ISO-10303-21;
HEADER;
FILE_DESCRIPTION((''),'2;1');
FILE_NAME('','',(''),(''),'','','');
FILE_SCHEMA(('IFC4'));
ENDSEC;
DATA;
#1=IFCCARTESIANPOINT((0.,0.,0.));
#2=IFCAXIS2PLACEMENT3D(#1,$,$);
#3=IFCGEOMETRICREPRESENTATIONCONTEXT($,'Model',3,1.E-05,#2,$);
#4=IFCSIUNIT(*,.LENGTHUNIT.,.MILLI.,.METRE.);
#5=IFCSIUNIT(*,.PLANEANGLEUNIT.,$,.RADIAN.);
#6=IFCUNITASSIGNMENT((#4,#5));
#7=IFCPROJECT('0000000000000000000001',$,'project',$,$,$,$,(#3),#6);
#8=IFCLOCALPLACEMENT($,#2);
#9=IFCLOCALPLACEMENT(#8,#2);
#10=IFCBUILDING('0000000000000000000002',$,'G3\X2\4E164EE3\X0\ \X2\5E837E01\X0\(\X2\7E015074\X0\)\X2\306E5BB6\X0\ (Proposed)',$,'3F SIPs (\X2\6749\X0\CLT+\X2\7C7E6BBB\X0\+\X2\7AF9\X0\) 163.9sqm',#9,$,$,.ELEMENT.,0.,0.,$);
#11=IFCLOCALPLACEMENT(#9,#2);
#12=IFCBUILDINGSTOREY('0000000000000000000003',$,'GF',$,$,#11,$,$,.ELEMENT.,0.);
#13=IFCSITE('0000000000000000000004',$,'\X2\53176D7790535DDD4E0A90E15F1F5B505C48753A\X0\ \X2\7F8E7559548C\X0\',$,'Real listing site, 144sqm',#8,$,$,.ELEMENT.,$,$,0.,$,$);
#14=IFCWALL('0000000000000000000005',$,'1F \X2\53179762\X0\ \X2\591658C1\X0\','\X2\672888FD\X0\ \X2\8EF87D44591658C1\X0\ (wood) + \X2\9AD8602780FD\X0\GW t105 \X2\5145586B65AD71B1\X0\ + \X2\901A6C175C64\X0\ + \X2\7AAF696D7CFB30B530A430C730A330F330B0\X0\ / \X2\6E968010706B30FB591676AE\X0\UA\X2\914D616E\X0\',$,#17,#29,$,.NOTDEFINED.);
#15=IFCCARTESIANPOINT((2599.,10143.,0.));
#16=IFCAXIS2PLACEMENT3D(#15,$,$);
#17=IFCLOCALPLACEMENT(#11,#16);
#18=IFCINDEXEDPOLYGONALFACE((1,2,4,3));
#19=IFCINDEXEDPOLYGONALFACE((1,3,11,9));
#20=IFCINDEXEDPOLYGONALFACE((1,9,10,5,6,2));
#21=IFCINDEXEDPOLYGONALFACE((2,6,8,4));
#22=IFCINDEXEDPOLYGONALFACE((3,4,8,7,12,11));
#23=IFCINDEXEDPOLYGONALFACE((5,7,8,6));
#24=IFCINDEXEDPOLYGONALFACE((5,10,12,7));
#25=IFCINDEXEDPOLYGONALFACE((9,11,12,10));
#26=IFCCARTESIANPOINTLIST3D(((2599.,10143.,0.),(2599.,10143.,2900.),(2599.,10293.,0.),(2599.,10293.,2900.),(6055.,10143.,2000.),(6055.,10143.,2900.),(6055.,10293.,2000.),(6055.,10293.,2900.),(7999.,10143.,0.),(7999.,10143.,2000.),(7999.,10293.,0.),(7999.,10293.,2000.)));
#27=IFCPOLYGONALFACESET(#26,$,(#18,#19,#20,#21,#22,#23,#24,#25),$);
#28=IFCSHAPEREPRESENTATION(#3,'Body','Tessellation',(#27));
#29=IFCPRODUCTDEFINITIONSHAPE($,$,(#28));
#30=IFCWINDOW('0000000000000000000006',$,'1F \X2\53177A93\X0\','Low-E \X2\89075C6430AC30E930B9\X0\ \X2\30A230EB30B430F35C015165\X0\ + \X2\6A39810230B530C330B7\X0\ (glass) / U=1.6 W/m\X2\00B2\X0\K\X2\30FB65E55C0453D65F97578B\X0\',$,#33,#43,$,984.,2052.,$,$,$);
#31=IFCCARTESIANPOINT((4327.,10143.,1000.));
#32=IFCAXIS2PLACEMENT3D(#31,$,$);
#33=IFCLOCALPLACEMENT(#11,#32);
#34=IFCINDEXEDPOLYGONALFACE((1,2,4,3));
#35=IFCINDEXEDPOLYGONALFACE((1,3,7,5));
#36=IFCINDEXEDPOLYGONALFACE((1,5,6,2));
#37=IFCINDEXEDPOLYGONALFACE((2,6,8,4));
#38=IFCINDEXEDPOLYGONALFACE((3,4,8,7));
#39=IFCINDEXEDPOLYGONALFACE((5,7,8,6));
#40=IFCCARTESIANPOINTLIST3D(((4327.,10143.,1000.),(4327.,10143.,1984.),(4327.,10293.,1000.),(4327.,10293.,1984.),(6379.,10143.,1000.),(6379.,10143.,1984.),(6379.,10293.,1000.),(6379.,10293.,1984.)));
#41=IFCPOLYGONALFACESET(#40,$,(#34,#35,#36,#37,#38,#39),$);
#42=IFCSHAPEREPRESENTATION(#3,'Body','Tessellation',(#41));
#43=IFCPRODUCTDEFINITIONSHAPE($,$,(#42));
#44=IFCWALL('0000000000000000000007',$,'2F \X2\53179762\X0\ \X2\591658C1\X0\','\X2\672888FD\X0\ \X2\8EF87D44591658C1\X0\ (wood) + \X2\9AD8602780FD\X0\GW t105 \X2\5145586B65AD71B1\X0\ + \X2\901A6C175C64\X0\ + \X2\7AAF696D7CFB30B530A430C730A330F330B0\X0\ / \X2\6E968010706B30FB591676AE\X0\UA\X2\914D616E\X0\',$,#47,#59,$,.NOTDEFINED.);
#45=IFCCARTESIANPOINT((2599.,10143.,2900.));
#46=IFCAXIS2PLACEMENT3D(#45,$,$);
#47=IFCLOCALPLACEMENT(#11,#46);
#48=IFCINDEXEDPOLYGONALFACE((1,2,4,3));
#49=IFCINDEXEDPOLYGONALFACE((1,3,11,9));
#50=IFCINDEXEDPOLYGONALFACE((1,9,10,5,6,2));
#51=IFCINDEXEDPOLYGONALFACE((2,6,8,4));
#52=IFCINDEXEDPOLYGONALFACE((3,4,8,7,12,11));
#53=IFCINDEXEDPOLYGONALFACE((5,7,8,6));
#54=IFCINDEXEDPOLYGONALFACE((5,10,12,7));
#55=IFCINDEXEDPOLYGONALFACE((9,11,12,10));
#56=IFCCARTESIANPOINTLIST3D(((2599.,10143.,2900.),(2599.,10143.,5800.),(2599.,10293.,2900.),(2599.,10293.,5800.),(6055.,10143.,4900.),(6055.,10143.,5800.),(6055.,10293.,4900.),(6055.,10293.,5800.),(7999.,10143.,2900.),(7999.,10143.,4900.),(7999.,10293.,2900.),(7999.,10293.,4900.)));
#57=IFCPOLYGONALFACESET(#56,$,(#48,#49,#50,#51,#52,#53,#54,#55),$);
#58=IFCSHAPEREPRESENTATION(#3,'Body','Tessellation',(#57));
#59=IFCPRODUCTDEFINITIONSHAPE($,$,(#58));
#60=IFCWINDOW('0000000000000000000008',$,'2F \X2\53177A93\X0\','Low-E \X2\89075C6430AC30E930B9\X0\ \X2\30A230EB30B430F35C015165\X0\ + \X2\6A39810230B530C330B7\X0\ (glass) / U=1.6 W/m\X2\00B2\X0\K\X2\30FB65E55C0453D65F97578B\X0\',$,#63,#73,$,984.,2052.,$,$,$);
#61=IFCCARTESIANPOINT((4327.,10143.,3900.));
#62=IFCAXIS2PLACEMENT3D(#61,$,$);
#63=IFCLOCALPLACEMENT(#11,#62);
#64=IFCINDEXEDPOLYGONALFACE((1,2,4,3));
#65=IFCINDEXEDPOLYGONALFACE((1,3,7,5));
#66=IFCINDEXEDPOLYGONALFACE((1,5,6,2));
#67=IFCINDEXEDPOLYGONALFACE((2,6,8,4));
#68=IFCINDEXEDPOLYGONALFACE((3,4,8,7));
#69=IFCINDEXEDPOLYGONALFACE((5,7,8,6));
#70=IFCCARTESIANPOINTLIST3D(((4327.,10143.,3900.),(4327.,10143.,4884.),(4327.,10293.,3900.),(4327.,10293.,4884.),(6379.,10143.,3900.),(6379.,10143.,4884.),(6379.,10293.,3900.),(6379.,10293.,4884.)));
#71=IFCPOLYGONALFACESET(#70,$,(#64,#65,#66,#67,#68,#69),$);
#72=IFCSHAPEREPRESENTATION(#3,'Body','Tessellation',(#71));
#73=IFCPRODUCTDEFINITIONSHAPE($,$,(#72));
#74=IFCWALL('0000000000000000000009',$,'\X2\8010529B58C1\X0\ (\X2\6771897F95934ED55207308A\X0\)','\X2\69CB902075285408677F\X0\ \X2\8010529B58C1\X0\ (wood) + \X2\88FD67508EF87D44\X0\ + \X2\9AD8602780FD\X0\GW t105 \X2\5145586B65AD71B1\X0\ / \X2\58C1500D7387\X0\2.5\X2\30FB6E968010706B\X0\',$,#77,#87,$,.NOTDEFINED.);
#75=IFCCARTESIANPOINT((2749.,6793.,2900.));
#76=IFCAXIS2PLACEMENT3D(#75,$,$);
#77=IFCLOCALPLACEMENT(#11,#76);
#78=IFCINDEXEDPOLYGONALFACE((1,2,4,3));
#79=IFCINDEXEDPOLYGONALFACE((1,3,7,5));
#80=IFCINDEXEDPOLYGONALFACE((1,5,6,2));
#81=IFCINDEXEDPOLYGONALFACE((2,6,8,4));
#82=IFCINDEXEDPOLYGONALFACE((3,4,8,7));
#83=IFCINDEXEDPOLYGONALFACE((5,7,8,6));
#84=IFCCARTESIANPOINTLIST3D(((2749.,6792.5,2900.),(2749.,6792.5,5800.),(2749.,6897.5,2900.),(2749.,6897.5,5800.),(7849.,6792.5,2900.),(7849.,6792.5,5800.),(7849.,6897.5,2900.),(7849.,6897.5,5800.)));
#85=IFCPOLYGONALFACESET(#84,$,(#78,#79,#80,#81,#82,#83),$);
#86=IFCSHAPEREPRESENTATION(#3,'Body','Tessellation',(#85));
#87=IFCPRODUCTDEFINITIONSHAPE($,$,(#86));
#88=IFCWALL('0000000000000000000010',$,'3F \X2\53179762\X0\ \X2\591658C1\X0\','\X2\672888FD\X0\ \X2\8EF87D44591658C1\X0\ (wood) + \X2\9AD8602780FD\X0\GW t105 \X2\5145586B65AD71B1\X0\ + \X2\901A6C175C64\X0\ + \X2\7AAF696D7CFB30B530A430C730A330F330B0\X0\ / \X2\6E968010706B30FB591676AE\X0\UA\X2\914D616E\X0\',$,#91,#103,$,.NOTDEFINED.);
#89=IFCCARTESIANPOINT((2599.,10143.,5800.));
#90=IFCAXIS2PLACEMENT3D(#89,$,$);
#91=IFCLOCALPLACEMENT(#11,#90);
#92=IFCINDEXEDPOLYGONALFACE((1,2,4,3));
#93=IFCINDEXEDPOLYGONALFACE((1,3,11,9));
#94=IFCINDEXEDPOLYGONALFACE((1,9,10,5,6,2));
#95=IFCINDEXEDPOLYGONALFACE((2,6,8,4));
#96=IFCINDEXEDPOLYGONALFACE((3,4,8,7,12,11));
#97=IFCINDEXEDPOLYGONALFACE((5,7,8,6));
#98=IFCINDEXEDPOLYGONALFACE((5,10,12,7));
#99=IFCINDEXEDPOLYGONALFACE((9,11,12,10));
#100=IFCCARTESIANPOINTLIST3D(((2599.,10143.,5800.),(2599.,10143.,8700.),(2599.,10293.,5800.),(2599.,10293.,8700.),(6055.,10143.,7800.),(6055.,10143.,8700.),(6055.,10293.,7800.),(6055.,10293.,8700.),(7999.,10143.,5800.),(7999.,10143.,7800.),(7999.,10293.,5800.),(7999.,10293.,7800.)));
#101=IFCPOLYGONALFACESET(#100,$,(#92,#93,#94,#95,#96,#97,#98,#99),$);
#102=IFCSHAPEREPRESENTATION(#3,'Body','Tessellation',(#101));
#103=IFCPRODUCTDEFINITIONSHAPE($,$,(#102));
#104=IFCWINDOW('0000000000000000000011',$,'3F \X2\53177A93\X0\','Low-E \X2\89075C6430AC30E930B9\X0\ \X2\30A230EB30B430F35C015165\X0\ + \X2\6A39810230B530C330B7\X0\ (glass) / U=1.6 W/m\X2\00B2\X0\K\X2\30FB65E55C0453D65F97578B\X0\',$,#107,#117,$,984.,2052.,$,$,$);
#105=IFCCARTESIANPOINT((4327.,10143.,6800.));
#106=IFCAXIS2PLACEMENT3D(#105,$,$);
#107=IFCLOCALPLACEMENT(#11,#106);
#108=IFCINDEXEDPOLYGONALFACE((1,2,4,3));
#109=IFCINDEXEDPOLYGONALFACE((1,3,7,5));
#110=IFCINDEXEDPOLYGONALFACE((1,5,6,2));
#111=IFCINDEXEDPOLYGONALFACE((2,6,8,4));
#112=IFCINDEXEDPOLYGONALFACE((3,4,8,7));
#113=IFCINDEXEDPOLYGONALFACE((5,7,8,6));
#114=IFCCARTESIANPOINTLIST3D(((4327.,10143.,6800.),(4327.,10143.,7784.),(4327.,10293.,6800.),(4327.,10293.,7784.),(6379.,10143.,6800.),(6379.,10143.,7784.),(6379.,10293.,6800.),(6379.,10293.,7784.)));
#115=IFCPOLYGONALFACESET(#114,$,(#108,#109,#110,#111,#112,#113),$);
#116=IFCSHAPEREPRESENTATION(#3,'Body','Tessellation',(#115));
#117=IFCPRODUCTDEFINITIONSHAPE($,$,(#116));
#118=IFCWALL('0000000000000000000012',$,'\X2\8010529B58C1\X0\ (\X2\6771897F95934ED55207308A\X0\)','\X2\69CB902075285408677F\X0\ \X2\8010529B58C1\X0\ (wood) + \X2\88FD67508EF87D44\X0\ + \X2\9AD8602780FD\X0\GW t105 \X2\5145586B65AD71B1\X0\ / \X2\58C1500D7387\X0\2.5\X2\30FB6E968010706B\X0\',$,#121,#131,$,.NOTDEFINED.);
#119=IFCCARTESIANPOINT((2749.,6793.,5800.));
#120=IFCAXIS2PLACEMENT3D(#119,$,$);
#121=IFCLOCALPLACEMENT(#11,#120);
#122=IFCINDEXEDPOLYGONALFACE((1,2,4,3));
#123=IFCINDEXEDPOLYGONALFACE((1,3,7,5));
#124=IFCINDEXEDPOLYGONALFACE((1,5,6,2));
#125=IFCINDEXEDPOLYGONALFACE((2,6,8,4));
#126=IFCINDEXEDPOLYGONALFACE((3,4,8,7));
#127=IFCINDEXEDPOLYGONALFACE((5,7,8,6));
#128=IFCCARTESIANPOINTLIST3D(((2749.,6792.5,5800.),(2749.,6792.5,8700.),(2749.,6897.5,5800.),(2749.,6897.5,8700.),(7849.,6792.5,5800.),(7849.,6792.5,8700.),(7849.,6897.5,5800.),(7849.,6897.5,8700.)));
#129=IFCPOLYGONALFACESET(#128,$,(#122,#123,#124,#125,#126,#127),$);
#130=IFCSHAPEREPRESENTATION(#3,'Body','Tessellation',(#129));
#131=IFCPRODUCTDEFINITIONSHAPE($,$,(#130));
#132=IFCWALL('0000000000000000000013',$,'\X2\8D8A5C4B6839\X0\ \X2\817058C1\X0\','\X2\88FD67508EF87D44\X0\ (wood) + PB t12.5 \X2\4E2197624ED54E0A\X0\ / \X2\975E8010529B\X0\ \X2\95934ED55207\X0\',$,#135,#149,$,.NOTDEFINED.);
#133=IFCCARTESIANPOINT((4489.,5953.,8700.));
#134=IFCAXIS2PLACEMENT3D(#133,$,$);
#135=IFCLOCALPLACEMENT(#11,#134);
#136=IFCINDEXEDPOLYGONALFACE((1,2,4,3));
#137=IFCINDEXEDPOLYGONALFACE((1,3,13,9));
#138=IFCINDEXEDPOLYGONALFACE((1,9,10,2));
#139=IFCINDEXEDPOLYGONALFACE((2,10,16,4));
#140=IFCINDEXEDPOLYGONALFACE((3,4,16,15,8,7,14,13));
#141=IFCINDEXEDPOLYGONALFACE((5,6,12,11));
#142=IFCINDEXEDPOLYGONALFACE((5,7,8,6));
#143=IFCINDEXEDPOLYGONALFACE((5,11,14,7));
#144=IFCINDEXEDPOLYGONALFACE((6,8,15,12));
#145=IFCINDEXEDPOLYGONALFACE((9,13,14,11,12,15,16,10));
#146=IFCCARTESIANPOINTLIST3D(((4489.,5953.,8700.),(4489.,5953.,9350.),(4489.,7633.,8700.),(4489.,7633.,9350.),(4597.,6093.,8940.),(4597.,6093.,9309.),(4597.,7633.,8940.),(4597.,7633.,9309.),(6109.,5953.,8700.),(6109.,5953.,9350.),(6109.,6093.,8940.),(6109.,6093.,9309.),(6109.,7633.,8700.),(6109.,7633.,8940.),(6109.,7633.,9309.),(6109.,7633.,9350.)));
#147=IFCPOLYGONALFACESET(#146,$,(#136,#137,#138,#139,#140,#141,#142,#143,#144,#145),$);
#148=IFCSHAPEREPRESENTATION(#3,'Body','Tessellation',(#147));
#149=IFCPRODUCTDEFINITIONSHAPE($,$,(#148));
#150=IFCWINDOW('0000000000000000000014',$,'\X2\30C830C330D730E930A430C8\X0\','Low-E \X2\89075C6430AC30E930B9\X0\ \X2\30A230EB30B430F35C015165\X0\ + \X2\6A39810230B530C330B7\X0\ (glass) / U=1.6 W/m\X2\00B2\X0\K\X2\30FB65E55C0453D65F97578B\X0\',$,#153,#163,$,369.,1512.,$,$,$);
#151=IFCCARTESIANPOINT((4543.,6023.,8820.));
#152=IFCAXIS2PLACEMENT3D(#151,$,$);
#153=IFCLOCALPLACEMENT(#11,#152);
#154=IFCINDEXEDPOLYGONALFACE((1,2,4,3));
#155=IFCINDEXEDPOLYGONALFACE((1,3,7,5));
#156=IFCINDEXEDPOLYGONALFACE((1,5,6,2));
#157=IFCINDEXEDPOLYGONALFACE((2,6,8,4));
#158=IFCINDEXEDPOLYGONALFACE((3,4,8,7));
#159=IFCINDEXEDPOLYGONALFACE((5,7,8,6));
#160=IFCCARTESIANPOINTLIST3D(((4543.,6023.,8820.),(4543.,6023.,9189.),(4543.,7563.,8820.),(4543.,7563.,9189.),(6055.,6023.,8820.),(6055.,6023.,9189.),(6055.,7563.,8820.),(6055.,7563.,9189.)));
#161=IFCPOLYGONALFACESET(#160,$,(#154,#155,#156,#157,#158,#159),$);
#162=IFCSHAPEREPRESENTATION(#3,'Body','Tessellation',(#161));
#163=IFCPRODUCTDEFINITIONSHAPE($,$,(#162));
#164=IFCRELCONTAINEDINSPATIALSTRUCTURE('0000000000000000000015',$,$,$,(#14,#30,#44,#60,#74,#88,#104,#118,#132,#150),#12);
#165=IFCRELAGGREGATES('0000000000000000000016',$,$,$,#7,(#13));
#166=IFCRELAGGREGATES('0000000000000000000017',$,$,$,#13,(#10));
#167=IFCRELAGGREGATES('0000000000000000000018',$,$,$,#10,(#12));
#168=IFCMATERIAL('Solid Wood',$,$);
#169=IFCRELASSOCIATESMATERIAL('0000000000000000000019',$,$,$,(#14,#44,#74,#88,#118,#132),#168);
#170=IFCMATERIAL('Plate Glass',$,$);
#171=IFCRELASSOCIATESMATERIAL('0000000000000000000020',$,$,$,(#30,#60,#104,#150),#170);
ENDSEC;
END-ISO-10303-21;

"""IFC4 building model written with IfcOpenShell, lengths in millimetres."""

from ifc_helpers import new_model, si_unit, frame, frame_2d, origin, place, context, project, spatial, rectangle, extrude, material, element, fill, save


model = new_model("IFC4")

# Units and contexts
model_context = context("Model", 3, precision=1e-05, world=origin())
ifc_project = project(units=[si_unit("LENGTHUNIT", "METRE", prefix="MILLI"), si_unit("PLANEANGLEUNIT", "RADIAN")], contexts=[model_context])

# Site, building, storey
site_placement = place(None, origin())
site = spatial("IfcSite", under=ifc_project, at=site_placement, Name="北海道川上郡弟子屈町 美留和", ObjectType="Real listing site, 144sqm", CompositionType="ELEMENT", RefElevation=0.0)
building_placement = place(site_placement, origin())
building = spatial("IfcBuilding", under=site, at=building_placement, Name="G3世代 広縁(縁側)の家 (Proposed)", ObjectType="3F SIPs (杉CLT+籾殻+竹) 163.9sqm", CompositionType="ELEMENT", ElevationOfRefHeight=0.0, ElevationOfTerrain=0.0)
storey_placement = place(building_placement, origin())
storey = spatial("IfcBuildingStorey", under=building, at=storey_placement, Name="GF", CompositionType="ELEMENT", Elevation=0.0)

# Wall, opening, window
ifc_material_1 = material(Name="Solid Wood")
wall_1_placement = place(storey_placement, frame((2599.0, 10143.0, 0.0)))
wall_1 = element("IfcWall", 1, at=wall_1_placement, inside=storey, material=ifc_material_1, Name="1F 北面 外壁", Description="木製 軸組外壁 (wood) + 高性能GW t105 充填断熱 + 通気層 + 窯業系サイディング / 準耐火・外皮UA配慮", PredefinedType="NOTDEFINED", context=model_context, shape_type="SweptSolid", body=[
    extrude(rectangle(XDim=5400.0, YDim=150.0, at=frame_2d((2700.0, 75.0))), frame((2599.0, 10143.0, 0.0)), (0.0, 0.0, 1.0), 2900.0),
])
opening_1_placement = place(storey_placement, frame((4327.0, 10143.0, 1000.0)))
opening_1 = element("IfcOpeningElement", 2, at=opening_1_placement, cuts=wall_1, PredefinedType="NOTDEFINED", context=model_context, shape_type="SweptSolid", body=[
    extrude(rectangle(XDim=2052.0, YDim=150.0, at=frame_2d((1026.0, 75.0))), frame((4327.0, 10143.0, 1000.0)), (0.0, 0.0, 1.0), 984.0),
])
ifc_material_2 = material(Name="Plate Glass")
window_1_placement = place(storey_placement, frame((4327.0, 10143.0, 1000.0)))
window_1 = element("IfcWindow", 3, at=window_1_placement, inside=storey, material=ifc_material_2, Name="1F 北窓", Description="Low-E 複層ガラス アルゴン封入 + 樹脂サッシ (glass) / U=1.6 W/m²K・日射取得型", OverallHeight=984.0, OverallWidth=2052.0, context=model_context, shape_type="SweptSolid", body=[
    extrude(rectangle(XDim=2052.0, YDim=150.0, at=frame_2d((1026.0, 75.0))), frame((4327.0, 10143.0, 1000.0)), (0.0, 0.0, 1.0), 984.0),
])
fill(opening_1, window_1)

# Wall, opening, window
wall_2_placement = place(storey_placement, frame((2599.0, 10143.0, 2900.0)))
wall_2 = element("IfcWall", 4, at=wall_2_placement, inside=storey, material=ifc_material_1, Name="2F 北面 外壁", Description="木製 軸組外壁 (wood) + 高性能GW t105 充填断熱 + 通気層 + 窯業系サイディング / 準耐火・外皮UA配慮", PredefinedType="NOTDEFINED", context=model_context, shape_type="SweptSolid", body=[
    extrude(rectangle(XDim=5400.0, YDim=150.0, at=frame_2d((2700.0, 75.0))), frame((2599.0, 10143.0, 2900.0)), (0.0, 0.0, 1.0), 2900.0),
])
opening_2_placement = place(storey_placement, frame((4327.0, 10143.0, 3900.0)))
opening_2 = element("IfcOpeningElement", 5, at=opening_2_placement, cuts=wall_2, PredefinedType="NOTDEFINED", context=model_context, shape_type="SweptSolid", body=[
    extrude(rectangle(XDim=2052.0, YDim=150.0, at=frame_2d((1026.0, 75.0))), frame((4327.0, 10143.0, 3900.0)), (0.0, 0.0, 1.0), 984.0),
])
window_2_placement = place(storey_placement, frame((4327.0, 10143.0, 3900.0)))
window_2 = element("IfcWindow", 6, at=window_2_placement, inside=storey, material=ifc_material_2, Name="2F 北窓", Description="Low-E 複層ガラス アルゴン封入 + 樹脂サッシ (glass) / U=1.6 W/m²K・日射取得型", OverallHeight=984.0, OverallWidth=2052.0, context=model_context, shape_type="SweptSolid", body=[
    extrude(rectangle(XDim=2052.0, YDim=150.0, at=frame_2d((1026.0, 75.0))), frame((4327.0, 10143.0, 3900.0)), (0.0, 0.0, 1.0), 984.0),
])
fill(opening_2, window_2)

# Wall
wall_3_placement = place(storey_placement, frame((2749.0, 6793.0, 2900.0)))
element("IfcWall", 7, at=wall_3_placement, inside=storey, material=ifc_material_1, Name="耐力壁 (東西間仕切り)", Description="構造用合板 耐力壁 (wood) + 製材軸組 + 高性能GW t105 充填断熱 / 壁倍率2.5・準耐火", PredefinedType="NOTDEFINED", context=model_context, shape_type="SweptSolid", body=[
    extrude(rectangle(XDim=5100.0, YDim=105.0, at=frame_2d((2550.0, 52.0))), frame((2749.0, 6793.0, 2900.0)), (0.0, 0.0, 1.0), 2900.0),
])

# Wall, opening, window
wall_4_placement = place(storey_placement, frame((2599.0, 10143.0, 5800.0)))
wall_4 = element("IfcWall", 8, at=wall_4_placement, inside=storey, material=ifc_material_1, Name="3F 北面 外壁", Description="木製 軸組外壁 (wood) + 高性能GW t105 充填断熱 + 通気層 + 窯業系サイディング / 準耐火・外皮UA配慮", PredefinedType="NOTDEFINED", context=model_context, shape_type="SweptSolid", body=[
    extrude(rectangle(XDim=5400.0, YDim=150.0, at=frame_2d((2700.0, 75.0))), frame((2599.0, 10143.0, 5800.0)), (0.0, 0.0, 1.0), 2900.0),
])
opening_3_placement = place(storey_placement, frame((4327.0, 10143.0, 6800.0)))
opening_3 = element("IfcOpeningElement", 9, at=opening_3_placement, cuts=wall_4, PredefinedType="NOTDEFINED", context=model_context, shape_type="SweptSolid", body=[
    extrude(rectangle(XDim=2052.0, YDim=150.0, at=frame_2d((1026.0, 75.0))), frame((4327.0, 10143.0, 6800.0)), (0.0, 0.0, 1.0), 984.0),
])
window_3_placement = place(storey_placement, frame((4327.0, 10143.0, 6800.0)))
window_3 = element("IfcWindow", 10, at=window_3_placement, inside=storey, material=ifc_material_2, Name="3F 北窓", Description="Low-E 複層ガラス アルゴン封入 + 樹脂サッシ (glass) / U=1.6 W/m²K・日射取得型", OverallHeight=984.0, OverallWidth=2052.0, context=model_context, shape_type="SweptSolid", body=[
    extrude(rectangle(XDim=2052.0, YDim=150.0, at=frame_2d((1026.0, 75.0))), frame((4327.0, 10143.0, 6800.0)), (0.0, 0.0, 1.0), 984.0),
])
fill(opening_3, window_3)

# Wall
wall_5_placement = place(storey_placement, frame((2749.0, 6793.0, 5800.0)))
element("IfcWall", 11, at=wall_5_placement, inside=storey, material=ifc_material_1, Name="耐力壁 (東西間仕切り)", Description="構造用合板 耐力壁 (wood) + 製材軸組 + 高性能GW t105 充填断熱 / 壁倍率2.5・準耐火", PredefinedType="NOTDEFINED", context=model_context, shape_type="SweptSolid", body=[
    extrude(rectangle(XDim=5100.0, YDim=105.0, at=frame_2d((2550.0, 52.0))), frame((2749.0, 6793.0, 5800.0)), (0.0, 0.0, 1.0), 2900.0),
])

# Wall, opening, window
wall_6_placement = place(storey_placement, frame((4489.0, 5953.0, 8700.0)))
wall_6 = element("IfcWall", 12, at=wall_6_placement, inside=storey, material=ifc_material_1, Name="越屋根 腰壁", Description="製材軸組 (wood) + PB t12.5 両面仕上 / 非耐力 間仕切", PredefinedType="NOTDEFINED", context=model_context, shape_type="SweptSolid", body=[
    extrude(rectangle(XDim=1620.0, YDim=1680.0, at=frame_2d((810.0, 840.0))), frame((4489.0, 5953.0, 8700.0)), (0.0, 0.0, 1.0), 650.0),
])
opening_4_placement = place(storey_placement, frame((4543.0, 6023.0, 8820.0)))
opening_4 = element("IfcOpeningElement", 13, at=opening_4_placement, cuts=wall_6, PredefinedType="NOTDEFINED", context=model_context, shape_type="SweptSolid", body=[
    extrude(rectangle(XDim=1512.0, YDim=1540.0, at=frame_2d((756.0, 770.0))), frame((4543.0, 6023.0, 8820.0)), (0.0, 0.0, 1.0), 369.0),
])
window_4_placement = place(storey_placement, frame((4543.0, 6023.0, 8820.0)))
window_4 = element("IfcWindow", 14, at=window_4_placement, inside=storey, material=ifc_material_2, Name="トップライト", Description="Low-E 複層ガラス アルゴン封入 + 樹脂サッシ (glass) / U=1.6 W/m²K・日射取得型", OverallHeight=369.0, OverallWidth=1512.0, context=model_context, shape_type="SweptSolid", body=[
    extrude(rectangle(XDim=1512.0, YDim=1540.0, at=frame_2d((756.0, 770.0))), frame((4543.0, 6023.0, 8820.0)), (0.0, 0.0, 1.0), 369.0),
])
fill(opening_4, window_4)

save(model, "model.ifc")
